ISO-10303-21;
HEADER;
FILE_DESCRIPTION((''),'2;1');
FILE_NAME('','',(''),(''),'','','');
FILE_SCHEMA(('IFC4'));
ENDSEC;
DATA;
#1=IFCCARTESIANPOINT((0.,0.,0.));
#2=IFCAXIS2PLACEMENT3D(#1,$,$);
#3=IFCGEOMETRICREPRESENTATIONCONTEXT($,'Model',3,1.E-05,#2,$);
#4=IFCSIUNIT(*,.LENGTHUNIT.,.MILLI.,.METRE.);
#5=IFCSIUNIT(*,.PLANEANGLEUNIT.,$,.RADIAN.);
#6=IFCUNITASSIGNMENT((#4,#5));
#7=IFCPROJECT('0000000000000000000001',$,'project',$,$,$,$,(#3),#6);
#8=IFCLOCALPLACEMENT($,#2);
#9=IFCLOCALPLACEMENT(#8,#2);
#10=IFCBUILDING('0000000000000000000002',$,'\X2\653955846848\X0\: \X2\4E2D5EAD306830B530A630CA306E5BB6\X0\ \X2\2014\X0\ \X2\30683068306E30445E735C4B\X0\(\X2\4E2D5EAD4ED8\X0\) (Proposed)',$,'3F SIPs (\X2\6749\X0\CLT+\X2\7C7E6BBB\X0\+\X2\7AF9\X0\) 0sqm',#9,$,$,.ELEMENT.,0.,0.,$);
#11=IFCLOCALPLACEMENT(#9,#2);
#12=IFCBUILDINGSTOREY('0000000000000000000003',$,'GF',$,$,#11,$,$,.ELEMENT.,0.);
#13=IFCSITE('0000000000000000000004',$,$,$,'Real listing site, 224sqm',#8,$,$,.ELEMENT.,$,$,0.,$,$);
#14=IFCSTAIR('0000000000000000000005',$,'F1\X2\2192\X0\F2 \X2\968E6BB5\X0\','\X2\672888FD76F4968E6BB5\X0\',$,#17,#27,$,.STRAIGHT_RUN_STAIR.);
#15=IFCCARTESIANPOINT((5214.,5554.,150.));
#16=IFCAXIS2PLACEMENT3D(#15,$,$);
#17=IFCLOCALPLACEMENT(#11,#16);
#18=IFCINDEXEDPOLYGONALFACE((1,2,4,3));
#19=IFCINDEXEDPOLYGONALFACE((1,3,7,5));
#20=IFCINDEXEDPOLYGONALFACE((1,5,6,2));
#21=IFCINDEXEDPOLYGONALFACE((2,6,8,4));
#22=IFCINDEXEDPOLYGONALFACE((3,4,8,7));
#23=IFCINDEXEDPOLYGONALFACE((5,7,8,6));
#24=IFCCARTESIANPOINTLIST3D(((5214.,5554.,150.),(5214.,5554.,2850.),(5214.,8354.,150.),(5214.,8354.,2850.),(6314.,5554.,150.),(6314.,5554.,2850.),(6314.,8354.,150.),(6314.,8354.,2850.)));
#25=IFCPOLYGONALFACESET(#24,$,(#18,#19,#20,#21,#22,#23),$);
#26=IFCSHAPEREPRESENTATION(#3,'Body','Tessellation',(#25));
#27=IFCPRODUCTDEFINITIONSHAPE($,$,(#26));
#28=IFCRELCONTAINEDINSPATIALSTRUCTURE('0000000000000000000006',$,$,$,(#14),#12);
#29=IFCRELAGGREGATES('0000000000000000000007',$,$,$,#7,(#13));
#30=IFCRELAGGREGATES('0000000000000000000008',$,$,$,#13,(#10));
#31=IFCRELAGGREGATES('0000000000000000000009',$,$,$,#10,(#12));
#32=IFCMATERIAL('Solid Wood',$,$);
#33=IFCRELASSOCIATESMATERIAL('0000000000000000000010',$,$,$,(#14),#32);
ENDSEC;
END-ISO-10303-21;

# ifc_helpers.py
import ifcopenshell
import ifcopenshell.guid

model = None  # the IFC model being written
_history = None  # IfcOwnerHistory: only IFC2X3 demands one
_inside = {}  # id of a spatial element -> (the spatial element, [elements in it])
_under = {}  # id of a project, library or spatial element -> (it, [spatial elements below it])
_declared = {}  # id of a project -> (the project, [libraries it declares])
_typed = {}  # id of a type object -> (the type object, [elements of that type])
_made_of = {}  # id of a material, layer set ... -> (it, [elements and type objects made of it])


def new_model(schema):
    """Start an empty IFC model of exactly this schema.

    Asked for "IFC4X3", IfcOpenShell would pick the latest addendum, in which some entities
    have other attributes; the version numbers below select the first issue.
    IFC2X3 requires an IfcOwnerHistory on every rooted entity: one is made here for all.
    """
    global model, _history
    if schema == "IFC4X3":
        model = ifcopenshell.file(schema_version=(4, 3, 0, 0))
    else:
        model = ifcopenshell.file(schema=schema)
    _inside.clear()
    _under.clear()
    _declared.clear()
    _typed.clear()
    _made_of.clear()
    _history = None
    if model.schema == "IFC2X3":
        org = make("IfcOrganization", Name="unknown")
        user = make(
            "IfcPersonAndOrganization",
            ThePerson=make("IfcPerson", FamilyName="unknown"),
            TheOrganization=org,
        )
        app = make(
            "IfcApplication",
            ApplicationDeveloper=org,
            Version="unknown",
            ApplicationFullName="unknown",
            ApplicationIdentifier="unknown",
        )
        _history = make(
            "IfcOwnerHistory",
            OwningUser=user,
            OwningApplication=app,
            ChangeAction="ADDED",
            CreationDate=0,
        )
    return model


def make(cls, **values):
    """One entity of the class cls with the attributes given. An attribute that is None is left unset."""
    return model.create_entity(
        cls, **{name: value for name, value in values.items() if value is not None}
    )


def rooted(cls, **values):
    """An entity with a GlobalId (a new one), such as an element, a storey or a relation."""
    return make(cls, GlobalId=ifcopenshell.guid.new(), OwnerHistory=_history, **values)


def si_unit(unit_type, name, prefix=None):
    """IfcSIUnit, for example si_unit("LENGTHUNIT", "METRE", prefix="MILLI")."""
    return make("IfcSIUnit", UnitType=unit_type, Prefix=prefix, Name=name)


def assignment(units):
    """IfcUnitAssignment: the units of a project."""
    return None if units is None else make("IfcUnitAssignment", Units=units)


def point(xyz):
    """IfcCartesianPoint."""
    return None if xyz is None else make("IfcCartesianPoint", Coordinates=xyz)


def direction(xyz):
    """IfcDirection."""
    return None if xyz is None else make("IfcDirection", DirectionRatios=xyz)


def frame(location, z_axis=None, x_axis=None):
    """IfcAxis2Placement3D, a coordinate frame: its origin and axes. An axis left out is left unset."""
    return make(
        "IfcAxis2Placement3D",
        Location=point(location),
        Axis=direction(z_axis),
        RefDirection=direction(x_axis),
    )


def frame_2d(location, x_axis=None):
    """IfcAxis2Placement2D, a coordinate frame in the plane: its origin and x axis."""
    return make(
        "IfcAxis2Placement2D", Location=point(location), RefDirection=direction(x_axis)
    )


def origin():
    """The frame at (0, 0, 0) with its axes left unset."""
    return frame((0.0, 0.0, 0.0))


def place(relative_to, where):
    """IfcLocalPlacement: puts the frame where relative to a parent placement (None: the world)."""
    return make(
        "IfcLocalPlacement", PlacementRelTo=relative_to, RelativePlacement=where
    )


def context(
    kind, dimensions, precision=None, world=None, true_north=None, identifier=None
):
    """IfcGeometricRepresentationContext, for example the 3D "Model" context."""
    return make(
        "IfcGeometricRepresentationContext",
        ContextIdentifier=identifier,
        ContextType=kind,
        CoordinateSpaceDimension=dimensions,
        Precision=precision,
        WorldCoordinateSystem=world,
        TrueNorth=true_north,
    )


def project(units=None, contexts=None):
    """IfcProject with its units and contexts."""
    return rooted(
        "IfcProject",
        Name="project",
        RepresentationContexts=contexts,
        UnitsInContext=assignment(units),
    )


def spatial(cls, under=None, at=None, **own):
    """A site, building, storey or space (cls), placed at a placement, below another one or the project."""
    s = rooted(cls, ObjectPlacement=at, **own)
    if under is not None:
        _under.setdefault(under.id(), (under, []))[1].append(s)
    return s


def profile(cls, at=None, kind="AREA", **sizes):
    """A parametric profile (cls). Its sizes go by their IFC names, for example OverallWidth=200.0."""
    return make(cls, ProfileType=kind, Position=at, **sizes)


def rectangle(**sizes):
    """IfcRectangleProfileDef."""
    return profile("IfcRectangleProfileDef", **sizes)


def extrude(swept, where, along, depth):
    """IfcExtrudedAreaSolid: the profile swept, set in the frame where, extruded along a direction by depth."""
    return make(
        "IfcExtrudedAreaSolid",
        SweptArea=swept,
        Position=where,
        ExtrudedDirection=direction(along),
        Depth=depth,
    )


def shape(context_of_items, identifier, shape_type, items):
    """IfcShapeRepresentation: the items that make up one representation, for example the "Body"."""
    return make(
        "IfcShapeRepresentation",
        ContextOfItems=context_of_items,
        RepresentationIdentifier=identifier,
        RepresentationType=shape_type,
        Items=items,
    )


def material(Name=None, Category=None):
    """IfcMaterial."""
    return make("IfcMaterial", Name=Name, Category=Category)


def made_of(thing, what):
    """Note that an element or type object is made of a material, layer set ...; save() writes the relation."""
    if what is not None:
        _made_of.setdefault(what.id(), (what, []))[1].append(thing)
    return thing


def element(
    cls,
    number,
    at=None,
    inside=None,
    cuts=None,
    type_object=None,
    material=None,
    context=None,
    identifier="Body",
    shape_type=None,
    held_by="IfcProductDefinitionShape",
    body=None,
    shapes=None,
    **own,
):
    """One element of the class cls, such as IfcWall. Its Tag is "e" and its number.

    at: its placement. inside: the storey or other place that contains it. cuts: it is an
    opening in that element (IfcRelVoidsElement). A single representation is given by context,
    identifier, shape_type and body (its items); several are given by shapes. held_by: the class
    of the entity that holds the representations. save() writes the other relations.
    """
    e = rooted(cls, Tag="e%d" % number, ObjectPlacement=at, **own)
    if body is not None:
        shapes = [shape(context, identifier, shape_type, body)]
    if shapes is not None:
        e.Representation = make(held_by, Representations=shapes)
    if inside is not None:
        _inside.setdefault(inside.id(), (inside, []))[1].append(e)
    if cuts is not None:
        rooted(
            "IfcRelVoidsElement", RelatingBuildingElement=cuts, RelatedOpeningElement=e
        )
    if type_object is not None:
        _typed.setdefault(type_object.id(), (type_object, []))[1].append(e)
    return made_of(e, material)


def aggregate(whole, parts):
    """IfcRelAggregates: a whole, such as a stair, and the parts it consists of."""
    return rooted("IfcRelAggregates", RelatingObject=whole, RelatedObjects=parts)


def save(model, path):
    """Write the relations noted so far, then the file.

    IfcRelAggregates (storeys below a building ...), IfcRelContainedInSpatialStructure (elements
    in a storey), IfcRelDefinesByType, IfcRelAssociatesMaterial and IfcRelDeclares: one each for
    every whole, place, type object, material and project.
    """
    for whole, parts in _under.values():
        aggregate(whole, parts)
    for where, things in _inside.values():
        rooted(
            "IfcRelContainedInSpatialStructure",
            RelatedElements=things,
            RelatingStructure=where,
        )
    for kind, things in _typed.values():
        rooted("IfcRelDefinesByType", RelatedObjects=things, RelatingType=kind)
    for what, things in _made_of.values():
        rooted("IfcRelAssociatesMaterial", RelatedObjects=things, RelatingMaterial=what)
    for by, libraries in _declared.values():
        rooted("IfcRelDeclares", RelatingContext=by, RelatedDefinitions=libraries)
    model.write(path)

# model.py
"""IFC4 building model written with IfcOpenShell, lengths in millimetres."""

from ifc_helpers import new_model, si_unit, frame, frame_2d, origin, place, context, project, spatial, rectangle, extrude, material, element, save


model = new_model("IFC4")

# Units and contexts
model_context = context("Model", 3, precision=1e-05, world=origin())
ifc_project = project(units=[si_unit("LENGTHUNIT", "METRE", prefix="MILLI"), si_unit("PLANEANGLEUNIT", "RADIAN")], contexts=[model_context])

# Site, building, storey
site_placement = place(None, origin())
site = spatial("IfcSite", under=ifc_project, at=site_placement, ObjectType="Real listing site, 224sqm", CompositionType="ELEMENT", RefElevation=0.0)
building_placement = place(site_placement, origin())
building = spatial("IfcBuilding", under=site, at=building_placement, Name="改善案: 中庭とサウナの家 — ととのい平屋(中庭付) (Proposed)", ObjectType="3F SIPs (杉CLT+籾殻+竹) 0sqm", CompositionType="ELEMENT", ElevationOfRefHeight=0.0, ElevationOfTerrain=0.0)
storey_placement = place(building_placement, origin())
storey = spatial("IfcBuildingStorey", under=building, at=storey_placement, Name="GF", CompositionType="ELEMENT", Elevation=0.0)

# Shared definitions
ifc_material_1 = material(Name="Solid Wood")

# Stair
stair_placement = place(storey_placement, frame((5214.0, 5554.0, 150.0)))
element("IfcStair", 1, at=stair_placement, inside=storey, material=ifc_material_1, Name="F1→F2 階段", Description="木製直階段", PredefinedType="STRAIGHT_RUN_STAIR", context=model_context, shape_type="SweptSolid", body=[
    extrude(rectangle(XDim=1100.0, YDim=2800.0, at=frame_2d((550.0, 1400.0))), frame((5214.0, 5554.0, 150.0)), (0.0, 0.0, 1.0), 2700.0),
])

save(model, "model.ifc")
